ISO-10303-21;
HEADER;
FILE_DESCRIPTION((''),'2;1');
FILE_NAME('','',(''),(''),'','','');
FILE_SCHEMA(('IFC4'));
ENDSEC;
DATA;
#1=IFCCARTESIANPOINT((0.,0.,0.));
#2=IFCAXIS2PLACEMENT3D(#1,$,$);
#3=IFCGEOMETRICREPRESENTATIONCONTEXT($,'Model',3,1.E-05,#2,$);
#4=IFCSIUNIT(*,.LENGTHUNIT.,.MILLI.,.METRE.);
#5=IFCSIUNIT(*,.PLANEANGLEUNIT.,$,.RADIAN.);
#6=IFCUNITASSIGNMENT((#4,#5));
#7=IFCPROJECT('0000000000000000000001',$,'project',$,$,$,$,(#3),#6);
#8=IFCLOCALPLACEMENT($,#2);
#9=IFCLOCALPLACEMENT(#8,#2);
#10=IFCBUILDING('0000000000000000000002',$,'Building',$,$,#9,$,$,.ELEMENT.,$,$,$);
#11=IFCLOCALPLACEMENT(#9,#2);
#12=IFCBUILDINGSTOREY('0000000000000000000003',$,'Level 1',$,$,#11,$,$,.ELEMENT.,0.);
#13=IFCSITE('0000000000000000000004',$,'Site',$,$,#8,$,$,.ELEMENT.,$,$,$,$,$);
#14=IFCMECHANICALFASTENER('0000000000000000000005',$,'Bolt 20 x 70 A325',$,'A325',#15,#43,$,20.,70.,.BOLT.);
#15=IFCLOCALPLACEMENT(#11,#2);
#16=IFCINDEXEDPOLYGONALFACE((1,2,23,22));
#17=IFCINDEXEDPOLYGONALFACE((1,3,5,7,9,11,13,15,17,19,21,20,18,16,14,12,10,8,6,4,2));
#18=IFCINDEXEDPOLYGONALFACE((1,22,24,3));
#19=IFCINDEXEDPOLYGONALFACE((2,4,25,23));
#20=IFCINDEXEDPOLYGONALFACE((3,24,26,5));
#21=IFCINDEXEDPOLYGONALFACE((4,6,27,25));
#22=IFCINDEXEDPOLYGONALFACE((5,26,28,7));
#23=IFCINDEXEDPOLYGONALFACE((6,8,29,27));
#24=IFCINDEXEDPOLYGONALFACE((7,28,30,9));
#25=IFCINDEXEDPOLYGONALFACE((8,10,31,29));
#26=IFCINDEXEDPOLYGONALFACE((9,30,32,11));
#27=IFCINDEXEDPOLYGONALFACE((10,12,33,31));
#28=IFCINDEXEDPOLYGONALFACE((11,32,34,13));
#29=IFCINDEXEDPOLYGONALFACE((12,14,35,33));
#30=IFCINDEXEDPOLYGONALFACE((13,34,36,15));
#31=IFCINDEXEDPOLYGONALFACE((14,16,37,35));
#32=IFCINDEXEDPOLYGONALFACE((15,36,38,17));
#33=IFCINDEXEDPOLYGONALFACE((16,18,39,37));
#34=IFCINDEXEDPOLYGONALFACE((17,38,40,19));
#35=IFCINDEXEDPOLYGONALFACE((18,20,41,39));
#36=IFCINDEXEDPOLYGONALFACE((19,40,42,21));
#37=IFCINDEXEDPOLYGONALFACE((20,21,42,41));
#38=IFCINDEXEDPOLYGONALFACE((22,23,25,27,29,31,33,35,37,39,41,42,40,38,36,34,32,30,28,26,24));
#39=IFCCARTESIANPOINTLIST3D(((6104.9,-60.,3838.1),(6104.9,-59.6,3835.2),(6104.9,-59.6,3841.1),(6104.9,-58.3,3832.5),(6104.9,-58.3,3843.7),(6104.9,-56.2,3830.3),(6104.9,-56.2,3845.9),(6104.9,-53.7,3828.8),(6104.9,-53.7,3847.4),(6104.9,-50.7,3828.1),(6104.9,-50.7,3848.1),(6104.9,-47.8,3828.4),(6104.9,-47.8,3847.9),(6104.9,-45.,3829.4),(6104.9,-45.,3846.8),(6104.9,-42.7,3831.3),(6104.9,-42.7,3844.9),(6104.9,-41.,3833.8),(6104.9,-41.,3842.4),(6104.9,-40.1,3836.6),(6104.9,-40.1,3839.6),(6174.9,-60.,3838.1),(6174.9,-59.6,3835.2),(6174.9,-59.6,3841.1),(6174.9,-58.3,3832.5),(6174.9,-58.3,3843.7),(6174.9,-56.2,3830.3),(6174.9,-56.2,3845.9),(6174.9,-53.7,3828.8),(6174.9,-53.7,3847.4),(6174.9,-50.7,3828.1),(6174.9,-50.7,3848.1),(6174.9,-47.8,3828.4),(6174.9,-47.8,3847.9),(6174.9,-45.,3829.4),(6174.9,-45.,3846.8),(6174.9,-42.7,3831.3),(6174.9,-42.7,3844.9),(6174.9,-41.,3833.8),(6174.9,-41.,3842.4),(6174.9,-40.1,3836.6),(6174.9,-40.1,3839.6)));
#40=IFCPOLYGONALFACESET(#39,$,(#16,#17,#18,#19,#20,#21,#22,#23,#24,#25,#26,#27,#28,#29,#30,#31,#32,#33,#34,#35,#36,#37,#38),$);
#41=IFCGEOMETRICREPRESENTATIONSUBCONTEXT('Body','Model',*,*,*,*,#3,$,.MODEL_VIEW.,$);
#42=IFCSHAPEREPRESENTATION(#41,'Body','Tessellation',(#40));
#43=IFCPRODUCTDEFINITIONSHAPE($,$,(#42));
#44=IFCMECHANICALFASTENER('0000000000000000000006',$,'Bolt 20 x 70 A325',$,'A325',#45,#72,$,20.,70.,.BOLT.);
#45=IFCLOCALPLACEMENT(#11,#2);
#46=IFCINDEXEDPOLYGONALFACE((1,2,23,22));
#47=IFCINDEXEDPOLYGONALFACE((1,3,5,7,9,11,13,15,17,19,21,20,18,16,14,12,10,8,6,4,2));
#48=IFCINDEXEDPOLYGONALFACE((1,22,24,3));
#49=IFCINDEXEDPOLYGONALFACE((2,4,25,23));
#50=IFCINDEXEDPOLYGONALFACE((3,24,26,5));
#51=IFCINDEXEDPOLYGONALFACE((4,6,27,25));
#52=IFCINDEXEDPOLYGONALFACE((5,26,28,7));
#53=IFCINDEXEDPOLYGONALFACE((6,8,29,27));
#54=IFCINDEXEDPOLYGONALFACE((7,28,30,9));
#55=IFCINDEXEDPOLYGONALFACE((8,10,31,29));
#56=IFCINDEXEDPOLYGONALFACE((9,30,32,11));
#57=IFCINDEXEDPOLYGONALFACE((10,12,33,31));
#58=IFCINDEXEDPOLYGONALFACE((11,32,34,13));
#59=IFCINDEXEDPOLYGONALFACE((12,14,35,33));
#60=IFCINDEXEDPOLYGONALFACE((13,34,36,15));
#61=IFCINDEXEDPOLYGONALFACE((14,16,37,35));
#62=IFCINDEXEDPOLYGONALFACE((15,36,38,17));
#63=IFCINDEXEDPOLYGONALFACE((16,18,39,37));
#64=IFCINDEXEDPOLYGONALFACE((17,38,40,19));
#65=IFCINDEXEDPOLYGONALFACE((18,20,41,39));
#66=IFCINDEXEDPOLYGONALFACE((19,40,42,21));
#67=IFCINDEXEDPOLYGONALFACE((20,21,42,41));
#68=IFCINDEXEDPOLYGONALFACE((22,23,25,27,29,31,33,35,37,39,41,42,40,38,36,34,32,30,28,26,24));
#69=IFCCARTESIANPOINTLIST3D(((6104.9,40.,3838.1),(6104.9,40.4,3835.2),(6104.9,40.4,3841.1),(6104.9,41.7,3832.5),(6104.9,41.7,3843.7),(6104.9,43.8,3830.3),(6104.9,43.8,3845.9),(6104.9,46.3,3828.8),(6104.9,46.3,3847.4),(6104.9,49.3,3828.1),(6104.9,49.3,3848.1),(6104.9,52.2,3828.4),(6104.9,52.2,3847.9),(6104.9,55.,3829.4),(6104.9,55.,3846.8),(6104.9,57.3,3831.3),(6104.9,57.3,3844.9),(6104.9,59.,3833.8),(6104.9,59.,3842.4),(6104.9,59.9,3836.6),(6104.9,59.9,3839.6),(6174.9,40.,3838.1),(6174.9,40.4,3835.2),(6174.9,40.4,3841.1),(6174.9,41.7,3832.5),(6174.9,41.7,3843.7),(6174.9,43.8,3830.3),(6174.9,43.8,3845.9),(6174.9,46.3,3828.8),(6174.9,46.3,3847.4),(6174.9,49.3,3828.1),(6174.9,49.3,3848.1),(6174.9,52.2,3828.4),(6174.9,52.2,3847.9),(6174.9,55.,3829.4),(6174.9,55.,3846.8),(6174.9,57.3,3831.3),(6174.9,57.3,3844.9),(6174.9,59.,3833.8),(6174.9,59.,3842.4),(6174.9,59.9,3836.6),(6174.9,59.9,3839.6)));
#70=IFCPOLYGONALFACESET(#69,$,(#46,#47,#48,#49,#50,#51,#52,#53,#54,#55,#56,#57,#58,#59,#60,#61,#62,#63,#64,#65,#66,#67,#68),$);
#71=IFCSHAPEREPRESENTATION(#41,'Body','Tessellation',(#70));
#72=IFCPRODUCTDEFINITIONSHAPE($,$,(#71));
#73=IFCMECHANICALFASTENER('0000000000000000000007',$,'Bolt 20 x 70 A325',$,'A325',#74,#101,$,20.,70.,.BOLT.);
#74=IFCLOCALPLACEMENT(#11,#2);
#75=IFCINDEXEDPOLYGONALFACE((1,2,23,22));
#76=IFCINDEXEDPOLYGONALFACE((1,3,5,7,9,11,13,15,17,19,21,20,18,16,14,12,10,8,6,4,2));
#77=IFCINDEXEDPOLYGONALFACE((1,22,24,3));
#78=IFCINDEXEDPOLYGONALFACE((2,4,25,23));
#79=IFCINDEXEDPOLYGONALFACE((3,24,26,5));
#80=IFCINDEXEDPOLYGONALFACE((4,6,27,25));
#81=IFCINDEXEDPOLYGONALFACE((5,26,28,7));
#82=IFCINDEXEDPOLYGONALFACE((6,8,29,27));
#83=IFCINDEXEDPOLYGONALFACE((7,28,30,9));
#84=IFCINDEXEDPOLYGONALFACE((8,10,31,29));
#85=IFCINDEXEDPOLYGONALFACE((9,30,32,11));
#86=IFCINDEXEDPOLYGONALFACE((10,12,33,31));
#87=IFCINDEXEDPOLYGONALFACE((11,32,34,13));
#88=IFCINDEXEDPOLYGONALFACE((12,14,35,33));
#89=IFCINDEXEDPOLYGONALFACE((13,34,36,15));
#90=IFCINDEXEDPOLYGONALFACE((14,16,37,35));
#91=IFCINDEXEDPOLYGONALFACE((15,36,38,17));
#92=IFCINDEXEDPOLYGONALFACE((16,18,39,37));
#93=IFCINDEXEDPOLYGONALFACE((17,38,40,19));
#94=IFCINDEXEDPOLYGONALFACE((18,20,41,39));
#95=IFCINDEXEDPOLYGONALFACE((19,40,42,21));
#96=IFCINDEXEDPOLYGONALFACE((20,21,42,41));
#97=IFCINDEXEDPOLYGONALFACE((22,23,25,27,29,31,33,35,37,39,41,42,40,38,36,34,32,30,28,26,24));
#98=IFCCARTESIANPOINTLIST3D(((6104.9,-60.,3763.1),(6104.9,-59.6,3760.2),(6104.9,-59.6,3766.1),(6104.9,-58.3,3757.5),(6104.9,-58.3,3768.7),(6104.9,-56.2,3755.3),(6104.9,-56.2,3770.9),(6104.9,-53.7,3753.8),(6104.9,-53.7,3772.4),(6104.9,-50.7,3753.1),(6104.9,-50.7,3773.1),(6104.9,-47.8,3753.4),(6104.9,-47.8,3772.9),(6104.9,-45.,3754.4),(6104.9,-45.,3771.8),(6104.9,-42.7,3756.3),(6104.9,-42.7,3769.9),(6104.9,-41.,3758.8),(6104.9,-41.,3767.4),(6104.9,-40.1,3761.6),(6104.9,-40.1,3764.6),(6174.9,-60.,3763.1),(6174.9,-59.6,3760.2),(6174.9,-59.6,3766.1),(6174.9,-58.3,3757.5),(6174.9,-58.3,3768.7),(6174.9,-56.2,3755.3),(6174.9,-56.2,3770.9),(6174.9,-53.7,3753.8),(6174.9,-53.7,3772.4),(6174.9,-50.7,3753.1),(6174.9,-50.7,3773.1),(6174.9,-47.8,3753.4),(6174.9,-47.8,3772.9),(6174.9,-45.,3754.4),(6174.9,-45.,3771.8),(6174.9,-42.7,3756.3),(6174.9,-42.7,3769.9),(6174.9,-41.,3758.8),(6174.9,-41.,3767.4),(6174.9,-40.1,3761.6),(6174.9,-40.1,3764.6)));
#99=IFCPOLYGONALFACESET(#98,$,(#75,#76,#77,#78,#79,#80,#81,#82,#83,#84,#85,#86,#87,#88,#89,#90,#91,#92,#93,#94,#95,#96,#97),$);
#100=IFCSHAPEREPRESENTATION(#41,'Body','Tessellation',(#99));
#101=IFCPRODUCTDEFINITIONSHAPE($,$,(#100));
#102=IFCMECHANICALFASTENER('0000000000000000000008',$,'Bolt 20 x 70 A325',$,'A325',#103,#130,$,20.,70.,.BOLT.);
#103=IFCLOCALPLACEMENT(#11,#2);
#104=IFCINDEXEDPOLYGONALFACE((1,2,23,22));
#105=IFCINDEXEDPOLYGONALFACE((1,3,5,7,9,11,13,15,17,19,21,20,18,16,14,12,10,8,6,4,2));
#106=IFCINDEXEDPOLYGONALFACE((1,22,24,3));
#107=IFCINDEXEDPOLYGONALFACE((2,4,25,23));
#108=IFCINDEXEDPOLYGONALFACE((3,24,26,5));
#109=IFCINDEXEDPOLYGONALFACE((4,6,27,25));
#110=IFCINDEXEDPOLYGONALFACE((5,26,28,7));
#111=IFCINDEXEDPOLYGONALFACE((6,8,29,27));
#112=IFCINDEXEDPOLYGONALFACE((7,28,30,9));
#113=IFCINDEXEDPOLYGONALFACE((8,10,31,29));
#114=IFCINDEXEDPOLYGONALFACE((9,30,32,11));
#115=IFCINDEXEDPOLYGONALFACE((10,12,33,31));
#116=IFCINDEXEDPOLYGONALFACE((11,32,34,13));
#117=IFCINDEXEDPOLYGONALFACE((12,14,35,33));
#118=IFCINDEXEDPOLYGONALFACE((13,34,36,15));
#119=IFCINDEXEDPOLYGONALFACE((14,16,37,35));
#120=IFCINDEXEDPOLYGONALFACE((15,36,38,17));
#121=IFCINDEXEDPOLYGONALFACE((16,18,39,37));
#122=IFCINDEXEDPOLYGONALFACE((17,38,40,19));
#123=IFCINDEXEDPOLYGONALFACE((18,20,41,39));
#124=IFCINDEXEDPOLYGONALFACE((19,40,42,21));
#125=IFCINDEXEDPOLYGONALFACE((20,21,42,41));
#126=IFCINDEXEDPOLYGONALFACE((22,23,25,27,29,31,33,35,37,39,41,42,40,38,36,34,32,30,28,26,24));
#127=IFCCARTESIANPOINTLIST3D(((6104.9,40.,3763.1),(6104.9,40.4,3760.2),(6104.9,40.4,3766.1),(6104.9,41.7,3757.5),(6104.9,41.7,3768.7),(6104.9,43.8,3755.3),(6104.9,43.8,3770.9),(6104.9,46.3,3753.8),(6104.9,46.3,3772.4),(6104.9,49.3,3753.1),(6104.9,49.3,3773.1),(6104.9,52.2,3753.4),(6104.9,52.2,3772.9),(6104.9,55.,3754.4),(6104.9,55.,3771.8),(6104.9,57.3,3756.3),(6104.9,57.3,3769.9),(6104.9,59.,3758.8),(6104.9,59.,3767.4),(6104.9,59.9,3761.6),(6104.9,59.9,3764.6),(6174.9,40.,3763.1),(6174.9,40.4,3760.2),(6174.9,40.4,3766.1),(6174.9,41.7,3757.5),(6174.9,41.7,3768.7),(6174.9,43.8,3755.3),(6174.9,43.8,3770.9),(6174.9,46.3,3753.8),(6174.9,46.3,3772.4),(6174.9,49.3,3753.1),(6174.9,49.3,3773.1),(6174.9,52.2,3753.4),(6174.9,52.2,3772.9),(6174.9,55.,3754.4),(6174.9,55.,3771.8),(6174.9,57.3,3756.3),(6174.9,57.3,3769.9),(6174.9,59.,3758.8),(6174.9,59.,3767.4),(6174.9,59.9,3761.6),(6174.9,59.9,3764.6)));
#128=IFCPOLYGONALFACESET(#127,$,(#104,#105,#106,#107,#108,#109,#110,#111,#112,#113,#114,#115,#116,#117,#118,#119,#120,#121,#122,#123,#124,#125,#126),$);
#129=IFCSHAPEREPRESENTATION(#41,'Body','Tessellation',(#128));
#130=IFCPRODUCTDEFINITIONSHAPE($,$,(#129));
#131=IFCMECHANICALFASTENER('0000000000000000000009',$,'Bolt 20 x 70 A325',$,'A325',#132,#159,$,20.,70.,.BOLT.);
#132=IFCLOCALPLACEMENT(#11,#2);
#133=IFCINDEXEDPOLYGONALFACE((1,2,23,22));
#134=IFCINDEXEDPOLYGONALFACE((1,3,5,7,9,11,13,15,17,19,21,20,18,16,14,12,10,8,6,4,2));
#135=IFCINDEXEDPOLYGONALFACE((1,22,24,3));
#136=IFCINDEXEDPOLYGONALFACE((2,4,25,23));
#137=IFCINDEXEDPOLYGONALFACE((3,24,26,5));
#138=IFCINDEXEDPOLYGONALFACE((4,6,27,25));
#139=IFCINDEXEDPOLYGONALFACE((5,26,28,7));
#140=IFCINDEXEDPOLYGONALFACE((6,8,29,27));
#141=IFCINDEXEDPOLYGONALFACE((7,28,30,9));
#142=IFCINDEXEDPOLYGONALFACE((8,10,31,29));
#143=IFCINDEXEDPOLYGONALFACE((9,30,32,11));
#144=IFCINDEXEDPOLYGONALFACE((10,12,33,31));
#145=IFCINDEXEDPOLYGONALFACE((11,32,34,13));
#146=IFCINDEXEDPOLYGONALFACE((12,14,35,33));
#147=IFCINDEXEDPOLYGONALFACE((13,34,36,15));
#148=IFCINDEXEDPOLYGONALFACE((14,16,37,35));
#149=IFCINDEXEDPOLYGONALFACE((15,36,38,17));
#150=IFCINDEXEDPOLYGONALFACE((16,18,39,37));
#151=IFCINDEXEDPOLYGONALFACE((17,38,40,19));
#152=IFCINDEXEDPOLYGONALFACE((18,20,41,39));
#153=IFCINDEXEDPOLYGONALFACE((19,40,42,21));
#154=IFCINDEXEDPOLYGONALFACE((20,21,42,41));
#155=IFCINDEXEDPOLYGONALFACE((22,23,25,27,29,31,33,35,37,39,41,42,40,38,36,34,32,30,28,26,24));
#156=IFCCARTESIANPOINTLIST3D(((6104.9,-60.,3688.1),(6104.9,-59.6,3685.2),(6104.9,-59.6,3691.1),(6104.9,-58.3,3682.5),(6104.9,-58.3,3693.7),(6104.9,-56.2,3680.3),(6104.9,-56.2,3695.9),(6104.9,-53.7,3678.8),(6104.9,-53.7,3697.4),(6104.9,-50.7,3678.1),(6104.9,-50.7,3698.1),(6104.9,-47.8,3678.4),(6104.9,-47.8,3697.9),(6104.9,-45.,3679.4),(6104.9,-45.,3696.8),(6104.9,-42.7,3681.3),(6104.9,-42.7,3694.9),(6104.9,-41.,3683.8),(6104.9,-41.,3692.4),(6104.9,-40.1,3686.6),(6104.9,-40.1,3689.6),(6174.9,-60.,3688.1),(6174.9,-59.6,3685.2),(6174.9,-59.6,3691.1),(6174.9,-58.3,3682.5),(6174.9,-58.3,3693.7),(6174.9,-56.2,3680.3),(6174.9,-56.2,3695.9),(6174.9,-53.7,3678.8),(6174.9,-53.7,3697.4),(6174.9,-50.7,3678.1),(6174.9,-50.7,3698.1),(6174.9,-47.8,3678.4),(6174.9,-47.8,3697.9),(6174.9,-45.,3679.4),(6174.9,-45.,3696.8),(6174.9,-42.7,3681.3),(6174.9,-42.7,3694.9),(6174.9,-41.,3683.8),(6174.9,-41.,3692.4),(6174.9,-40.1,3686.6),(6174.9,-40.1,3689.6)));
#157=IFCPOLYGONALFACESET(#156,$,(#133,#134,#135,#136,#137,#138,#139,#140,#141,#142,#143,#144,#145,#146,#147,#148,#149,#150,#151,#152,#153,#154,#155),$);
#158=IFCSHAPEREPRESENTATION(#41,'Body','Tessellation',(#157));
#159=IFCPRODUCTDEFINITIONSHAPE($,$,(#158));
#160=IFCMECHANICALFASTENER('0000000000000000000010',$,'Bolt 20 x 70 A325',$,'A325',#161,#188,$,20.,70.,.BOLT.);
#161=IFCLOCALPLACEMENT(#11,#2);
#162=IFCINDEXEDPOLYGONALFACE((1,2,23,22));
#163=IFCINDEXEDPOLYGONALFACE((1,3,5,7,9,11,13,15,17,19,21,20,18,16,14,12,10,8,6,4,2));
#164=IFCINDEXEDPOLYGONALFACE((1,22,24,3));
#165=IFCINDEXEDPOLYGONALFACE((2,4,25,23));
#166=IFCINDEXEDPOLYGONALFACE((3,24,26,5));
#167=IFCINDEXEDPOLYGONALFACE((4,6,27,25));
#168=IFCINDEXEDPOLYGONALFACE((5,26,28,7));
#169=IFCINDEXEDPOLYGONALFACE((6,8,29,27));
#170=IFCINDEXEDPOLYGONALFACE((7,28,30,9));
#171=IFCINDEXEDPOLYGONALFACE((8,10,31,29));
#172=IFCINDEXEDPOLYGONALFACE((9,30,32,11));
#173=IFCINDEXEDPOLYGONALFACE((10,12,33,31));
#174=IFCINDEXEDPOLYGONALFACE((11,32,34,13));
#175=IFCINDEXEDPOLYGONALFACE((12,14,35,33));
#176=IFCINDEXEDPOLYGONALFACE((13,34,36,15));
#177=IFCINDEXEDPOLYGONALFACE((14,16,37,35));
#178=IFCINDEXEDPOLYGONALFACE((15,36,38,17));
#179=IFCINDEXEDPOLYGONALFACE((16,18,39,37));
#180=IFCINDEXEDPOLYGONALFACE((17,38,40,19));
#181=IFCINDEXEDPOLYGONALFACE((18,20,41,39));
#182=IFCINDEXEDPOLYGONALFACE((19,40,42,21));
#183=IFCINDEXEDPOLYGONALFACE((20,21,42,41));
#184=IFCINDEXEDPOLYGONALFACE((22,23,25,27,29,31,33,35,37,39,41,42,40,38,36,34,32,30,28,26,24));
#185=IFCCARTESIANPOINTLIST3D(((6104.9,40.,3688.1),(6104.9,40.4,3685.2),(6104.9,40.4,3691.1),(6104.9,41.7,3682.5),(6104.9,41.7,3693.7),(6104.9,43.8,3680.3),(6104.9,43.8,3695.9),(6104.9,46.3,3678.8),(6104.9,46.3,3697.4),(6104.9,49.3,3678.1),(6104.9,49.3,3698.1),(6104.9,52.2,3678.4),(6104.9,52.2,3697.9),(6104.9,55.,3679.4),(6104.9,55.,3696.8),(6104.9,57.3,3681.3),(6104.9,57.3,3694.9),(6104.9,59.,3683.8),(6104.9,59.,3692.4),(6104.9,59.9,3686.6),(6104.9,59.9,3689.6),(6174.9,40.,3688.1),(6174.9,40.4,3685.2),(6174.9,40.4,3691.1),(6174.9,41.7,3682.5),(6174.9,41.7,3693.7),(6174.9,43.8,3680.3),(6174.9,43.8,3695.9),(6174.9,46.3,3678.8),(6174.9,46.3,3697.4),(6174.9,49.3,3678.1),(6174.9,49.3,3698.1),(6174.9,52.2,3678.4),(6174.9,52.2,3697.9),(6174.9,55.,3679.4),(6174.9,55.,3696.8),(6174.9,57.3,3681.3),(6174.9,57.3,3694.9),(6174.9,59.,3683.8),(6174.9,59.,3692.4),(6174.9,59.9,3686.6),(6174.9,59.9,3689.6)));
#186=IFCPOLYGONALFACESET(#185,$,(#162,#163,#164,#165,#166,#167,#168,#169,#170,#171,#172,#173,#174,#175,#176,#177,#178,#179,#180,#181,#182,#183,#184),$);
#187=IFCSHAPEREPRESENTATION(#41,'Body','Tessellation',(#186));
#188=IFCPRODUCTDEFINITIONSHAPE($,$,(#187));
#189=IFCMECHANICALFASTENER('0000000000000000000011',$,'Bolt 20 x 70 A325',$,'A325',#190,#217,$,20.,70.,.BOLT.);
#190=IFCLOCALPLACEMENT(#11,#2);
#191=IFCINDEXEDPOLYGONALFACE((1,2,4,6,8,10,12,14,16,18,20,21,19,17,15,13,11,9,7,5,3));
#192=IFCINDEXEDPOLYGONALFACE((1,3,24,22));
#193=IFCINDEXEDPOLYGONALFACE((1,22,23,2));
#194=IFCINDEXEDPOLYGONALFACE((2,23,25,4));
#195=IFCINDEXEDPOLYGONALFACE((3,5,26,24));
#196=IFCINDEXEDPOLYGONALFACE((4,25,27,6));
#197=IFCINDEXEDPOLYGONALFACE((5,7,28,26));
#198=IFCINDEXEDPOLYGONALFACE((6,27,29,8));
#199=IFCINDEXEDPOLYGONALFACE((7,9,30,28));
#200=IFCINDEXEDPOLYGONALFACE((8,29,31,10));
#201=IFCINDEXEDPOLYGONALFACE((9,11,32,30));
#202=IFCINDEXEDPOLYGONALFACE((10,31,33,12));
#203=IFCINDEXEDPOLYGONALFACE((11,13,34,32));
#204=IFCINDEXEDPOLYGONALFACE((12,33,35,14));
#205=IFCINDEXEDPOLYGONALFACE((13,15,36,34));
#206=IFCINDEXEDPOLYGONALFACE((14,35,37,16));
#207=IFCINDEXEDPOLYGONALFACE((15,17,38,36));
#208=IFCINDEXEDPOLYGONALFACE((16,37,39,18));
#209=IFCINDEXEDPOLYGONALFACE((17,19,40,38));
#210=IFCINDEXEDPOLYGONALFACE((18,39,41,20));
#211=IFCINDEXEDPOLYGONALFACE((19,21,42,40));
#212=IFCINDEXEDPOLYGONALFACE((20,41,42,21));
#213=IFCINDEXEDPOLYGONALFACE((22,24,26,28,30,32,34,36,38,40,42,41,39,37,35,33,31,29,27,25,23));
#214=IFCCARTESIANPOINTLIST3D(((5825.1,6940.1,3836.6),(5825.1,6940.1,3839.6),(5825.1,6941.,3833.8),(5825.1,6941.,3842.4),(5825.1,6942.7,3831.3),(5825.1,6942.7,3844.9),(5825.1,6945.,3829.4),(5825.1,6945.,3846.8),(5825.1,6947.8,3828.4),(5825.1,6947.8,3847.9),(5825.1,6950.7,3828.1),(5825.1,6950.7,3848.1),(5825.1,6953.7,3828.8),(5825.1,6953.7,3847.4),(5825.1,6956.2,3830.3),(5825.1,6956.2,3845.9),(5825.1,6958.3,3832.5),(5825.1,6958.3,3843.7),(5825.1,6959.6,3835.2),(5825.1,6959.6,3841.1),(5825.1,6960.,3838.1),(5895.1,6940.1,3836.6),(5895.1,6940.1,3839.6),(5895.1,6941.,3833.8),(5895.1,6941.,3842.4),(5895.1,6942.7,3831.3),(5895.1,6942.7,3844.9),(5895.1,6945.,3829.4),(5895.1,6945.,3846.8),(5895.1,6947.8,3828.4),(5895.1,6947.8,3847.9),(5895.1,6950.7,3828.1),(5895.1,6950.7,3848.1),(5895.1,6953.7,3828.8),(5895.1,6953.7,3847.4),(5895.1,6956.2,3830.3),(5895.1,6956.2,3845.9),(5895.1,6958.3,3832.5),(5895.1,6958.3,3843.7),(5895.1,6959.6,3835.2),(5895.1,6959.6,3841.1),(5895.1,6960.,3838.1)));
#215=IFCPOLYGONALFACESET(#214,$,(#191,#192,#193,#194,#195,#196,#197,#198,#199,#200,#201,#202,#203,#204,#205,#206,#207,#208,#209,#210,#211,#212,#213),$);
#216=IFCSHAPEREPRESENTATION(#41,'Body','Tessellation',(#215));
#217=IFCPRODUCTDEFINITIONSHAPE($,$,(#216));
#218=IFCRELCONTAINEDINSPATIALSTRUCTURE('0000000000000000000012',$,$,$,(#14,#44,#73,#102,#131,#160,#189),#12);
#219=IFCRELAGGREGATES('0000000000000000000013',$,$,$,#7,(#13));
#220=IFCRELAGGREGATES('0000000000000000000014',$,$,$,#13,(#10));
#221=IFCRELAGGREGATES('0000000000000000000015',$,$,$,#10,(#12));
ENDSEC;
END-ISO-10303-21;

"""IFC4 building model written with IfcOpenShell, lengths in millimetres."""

from ifc_helpers import new_model, si_unit, frame, origin, origin_2d, place, context, subcontext, project, spatial, circle, extrude, element, save


model = new_model("IFC4")

# Units and contexts
model_context = context("Model", 3, precision=1e-05, world=origin())
body_context = subcontext(model_context, "Body", "Model", "MODEL_VIEW")
ifc_project = project(units=[si_unit("LENGTHUNIT", "METRE", prefix="MILLI"), si_unit("PLANEANGLEUNIT", "RADIAN")], contexts=[model_context])

# Site, building, storey
site_placement = place(None, origin())
site = spatial("IfcSite", under=ifc_project, at=site_placement, Name="Site", CompositionType="ELEMENT")
building_placement = place(site_placement, origin())
building = spatial("IfcBuilding", under=site, at=building_placement, Name="Building", CompositionType="ELEMENT")
storey_placement = place(building_placement, origin())
storey = spatial("IfcBuildingStorey", under=building, at=storey_placement, Name="Level 1", CompositionType="ELEMENT", Elevation=0.0)

# Mechanical fasteners
for number, where, z_axis, x_axis, name in (
    (1, (6174.9, -50.0, 3838.1), (-1.0, 0.0, 0.0), (0.0, -1.0, 0.0), "Bolt 20 x 70 A325"),
    (2, (6174.9, 50.0, 3838.1), (-1.0, 0.0, 0.0), (0.0, -1.0, 0.0), "Bolt 20 x 70 A325"),
    (3, (6174.9, -50.0, 3763.1), (-1.0, 0.0, 0.0), (0.0, -1.0, 0.0), "Bolt 20 x 70 A325"),
    (4, (6174.9, 50.0, 3763.1), (-1.0, 0.0, 0.0), (0.0, -1.0, 0.0), "Bolt 20 x 70 A325"),
    (5, (6174.9, -50.0, 3688.1), (-1.0, 0.0, 0.0), (0.0, -1.0, 0.0), "Bolt 20 x 70 A325"),
    (6, (6174.9, 50.0, 3688.1), (-1.0, 0.0, 0.0), (0.0, -1.0, 0.0), "Bolt 20 x 70 A325"),
    (7, (5825.1, 6950.0, 3838.1), (1.0, 0.0, 0.0), (0.0, 1.0, 0.0), "Bolt 20 x 70 A325"),
):
    element("IfcMechanicalFastener", number, at=place(storey_placement, frame(where, z_axis=z_axis, x_axis=x_axis)), inside=storey, Name=name, ObjectType="A325", NominalDiameter=20.0, NominalLength=70.0, PredefinedType="BOLT", context=body_context, shape_type="SweptSolid", body=[
        extrude(circle(Radius=10.0, at=origin_2d()), origin(), (0.0, 0.0, 1.0), 70.0),
    ])

save(model, "model.ifc")
